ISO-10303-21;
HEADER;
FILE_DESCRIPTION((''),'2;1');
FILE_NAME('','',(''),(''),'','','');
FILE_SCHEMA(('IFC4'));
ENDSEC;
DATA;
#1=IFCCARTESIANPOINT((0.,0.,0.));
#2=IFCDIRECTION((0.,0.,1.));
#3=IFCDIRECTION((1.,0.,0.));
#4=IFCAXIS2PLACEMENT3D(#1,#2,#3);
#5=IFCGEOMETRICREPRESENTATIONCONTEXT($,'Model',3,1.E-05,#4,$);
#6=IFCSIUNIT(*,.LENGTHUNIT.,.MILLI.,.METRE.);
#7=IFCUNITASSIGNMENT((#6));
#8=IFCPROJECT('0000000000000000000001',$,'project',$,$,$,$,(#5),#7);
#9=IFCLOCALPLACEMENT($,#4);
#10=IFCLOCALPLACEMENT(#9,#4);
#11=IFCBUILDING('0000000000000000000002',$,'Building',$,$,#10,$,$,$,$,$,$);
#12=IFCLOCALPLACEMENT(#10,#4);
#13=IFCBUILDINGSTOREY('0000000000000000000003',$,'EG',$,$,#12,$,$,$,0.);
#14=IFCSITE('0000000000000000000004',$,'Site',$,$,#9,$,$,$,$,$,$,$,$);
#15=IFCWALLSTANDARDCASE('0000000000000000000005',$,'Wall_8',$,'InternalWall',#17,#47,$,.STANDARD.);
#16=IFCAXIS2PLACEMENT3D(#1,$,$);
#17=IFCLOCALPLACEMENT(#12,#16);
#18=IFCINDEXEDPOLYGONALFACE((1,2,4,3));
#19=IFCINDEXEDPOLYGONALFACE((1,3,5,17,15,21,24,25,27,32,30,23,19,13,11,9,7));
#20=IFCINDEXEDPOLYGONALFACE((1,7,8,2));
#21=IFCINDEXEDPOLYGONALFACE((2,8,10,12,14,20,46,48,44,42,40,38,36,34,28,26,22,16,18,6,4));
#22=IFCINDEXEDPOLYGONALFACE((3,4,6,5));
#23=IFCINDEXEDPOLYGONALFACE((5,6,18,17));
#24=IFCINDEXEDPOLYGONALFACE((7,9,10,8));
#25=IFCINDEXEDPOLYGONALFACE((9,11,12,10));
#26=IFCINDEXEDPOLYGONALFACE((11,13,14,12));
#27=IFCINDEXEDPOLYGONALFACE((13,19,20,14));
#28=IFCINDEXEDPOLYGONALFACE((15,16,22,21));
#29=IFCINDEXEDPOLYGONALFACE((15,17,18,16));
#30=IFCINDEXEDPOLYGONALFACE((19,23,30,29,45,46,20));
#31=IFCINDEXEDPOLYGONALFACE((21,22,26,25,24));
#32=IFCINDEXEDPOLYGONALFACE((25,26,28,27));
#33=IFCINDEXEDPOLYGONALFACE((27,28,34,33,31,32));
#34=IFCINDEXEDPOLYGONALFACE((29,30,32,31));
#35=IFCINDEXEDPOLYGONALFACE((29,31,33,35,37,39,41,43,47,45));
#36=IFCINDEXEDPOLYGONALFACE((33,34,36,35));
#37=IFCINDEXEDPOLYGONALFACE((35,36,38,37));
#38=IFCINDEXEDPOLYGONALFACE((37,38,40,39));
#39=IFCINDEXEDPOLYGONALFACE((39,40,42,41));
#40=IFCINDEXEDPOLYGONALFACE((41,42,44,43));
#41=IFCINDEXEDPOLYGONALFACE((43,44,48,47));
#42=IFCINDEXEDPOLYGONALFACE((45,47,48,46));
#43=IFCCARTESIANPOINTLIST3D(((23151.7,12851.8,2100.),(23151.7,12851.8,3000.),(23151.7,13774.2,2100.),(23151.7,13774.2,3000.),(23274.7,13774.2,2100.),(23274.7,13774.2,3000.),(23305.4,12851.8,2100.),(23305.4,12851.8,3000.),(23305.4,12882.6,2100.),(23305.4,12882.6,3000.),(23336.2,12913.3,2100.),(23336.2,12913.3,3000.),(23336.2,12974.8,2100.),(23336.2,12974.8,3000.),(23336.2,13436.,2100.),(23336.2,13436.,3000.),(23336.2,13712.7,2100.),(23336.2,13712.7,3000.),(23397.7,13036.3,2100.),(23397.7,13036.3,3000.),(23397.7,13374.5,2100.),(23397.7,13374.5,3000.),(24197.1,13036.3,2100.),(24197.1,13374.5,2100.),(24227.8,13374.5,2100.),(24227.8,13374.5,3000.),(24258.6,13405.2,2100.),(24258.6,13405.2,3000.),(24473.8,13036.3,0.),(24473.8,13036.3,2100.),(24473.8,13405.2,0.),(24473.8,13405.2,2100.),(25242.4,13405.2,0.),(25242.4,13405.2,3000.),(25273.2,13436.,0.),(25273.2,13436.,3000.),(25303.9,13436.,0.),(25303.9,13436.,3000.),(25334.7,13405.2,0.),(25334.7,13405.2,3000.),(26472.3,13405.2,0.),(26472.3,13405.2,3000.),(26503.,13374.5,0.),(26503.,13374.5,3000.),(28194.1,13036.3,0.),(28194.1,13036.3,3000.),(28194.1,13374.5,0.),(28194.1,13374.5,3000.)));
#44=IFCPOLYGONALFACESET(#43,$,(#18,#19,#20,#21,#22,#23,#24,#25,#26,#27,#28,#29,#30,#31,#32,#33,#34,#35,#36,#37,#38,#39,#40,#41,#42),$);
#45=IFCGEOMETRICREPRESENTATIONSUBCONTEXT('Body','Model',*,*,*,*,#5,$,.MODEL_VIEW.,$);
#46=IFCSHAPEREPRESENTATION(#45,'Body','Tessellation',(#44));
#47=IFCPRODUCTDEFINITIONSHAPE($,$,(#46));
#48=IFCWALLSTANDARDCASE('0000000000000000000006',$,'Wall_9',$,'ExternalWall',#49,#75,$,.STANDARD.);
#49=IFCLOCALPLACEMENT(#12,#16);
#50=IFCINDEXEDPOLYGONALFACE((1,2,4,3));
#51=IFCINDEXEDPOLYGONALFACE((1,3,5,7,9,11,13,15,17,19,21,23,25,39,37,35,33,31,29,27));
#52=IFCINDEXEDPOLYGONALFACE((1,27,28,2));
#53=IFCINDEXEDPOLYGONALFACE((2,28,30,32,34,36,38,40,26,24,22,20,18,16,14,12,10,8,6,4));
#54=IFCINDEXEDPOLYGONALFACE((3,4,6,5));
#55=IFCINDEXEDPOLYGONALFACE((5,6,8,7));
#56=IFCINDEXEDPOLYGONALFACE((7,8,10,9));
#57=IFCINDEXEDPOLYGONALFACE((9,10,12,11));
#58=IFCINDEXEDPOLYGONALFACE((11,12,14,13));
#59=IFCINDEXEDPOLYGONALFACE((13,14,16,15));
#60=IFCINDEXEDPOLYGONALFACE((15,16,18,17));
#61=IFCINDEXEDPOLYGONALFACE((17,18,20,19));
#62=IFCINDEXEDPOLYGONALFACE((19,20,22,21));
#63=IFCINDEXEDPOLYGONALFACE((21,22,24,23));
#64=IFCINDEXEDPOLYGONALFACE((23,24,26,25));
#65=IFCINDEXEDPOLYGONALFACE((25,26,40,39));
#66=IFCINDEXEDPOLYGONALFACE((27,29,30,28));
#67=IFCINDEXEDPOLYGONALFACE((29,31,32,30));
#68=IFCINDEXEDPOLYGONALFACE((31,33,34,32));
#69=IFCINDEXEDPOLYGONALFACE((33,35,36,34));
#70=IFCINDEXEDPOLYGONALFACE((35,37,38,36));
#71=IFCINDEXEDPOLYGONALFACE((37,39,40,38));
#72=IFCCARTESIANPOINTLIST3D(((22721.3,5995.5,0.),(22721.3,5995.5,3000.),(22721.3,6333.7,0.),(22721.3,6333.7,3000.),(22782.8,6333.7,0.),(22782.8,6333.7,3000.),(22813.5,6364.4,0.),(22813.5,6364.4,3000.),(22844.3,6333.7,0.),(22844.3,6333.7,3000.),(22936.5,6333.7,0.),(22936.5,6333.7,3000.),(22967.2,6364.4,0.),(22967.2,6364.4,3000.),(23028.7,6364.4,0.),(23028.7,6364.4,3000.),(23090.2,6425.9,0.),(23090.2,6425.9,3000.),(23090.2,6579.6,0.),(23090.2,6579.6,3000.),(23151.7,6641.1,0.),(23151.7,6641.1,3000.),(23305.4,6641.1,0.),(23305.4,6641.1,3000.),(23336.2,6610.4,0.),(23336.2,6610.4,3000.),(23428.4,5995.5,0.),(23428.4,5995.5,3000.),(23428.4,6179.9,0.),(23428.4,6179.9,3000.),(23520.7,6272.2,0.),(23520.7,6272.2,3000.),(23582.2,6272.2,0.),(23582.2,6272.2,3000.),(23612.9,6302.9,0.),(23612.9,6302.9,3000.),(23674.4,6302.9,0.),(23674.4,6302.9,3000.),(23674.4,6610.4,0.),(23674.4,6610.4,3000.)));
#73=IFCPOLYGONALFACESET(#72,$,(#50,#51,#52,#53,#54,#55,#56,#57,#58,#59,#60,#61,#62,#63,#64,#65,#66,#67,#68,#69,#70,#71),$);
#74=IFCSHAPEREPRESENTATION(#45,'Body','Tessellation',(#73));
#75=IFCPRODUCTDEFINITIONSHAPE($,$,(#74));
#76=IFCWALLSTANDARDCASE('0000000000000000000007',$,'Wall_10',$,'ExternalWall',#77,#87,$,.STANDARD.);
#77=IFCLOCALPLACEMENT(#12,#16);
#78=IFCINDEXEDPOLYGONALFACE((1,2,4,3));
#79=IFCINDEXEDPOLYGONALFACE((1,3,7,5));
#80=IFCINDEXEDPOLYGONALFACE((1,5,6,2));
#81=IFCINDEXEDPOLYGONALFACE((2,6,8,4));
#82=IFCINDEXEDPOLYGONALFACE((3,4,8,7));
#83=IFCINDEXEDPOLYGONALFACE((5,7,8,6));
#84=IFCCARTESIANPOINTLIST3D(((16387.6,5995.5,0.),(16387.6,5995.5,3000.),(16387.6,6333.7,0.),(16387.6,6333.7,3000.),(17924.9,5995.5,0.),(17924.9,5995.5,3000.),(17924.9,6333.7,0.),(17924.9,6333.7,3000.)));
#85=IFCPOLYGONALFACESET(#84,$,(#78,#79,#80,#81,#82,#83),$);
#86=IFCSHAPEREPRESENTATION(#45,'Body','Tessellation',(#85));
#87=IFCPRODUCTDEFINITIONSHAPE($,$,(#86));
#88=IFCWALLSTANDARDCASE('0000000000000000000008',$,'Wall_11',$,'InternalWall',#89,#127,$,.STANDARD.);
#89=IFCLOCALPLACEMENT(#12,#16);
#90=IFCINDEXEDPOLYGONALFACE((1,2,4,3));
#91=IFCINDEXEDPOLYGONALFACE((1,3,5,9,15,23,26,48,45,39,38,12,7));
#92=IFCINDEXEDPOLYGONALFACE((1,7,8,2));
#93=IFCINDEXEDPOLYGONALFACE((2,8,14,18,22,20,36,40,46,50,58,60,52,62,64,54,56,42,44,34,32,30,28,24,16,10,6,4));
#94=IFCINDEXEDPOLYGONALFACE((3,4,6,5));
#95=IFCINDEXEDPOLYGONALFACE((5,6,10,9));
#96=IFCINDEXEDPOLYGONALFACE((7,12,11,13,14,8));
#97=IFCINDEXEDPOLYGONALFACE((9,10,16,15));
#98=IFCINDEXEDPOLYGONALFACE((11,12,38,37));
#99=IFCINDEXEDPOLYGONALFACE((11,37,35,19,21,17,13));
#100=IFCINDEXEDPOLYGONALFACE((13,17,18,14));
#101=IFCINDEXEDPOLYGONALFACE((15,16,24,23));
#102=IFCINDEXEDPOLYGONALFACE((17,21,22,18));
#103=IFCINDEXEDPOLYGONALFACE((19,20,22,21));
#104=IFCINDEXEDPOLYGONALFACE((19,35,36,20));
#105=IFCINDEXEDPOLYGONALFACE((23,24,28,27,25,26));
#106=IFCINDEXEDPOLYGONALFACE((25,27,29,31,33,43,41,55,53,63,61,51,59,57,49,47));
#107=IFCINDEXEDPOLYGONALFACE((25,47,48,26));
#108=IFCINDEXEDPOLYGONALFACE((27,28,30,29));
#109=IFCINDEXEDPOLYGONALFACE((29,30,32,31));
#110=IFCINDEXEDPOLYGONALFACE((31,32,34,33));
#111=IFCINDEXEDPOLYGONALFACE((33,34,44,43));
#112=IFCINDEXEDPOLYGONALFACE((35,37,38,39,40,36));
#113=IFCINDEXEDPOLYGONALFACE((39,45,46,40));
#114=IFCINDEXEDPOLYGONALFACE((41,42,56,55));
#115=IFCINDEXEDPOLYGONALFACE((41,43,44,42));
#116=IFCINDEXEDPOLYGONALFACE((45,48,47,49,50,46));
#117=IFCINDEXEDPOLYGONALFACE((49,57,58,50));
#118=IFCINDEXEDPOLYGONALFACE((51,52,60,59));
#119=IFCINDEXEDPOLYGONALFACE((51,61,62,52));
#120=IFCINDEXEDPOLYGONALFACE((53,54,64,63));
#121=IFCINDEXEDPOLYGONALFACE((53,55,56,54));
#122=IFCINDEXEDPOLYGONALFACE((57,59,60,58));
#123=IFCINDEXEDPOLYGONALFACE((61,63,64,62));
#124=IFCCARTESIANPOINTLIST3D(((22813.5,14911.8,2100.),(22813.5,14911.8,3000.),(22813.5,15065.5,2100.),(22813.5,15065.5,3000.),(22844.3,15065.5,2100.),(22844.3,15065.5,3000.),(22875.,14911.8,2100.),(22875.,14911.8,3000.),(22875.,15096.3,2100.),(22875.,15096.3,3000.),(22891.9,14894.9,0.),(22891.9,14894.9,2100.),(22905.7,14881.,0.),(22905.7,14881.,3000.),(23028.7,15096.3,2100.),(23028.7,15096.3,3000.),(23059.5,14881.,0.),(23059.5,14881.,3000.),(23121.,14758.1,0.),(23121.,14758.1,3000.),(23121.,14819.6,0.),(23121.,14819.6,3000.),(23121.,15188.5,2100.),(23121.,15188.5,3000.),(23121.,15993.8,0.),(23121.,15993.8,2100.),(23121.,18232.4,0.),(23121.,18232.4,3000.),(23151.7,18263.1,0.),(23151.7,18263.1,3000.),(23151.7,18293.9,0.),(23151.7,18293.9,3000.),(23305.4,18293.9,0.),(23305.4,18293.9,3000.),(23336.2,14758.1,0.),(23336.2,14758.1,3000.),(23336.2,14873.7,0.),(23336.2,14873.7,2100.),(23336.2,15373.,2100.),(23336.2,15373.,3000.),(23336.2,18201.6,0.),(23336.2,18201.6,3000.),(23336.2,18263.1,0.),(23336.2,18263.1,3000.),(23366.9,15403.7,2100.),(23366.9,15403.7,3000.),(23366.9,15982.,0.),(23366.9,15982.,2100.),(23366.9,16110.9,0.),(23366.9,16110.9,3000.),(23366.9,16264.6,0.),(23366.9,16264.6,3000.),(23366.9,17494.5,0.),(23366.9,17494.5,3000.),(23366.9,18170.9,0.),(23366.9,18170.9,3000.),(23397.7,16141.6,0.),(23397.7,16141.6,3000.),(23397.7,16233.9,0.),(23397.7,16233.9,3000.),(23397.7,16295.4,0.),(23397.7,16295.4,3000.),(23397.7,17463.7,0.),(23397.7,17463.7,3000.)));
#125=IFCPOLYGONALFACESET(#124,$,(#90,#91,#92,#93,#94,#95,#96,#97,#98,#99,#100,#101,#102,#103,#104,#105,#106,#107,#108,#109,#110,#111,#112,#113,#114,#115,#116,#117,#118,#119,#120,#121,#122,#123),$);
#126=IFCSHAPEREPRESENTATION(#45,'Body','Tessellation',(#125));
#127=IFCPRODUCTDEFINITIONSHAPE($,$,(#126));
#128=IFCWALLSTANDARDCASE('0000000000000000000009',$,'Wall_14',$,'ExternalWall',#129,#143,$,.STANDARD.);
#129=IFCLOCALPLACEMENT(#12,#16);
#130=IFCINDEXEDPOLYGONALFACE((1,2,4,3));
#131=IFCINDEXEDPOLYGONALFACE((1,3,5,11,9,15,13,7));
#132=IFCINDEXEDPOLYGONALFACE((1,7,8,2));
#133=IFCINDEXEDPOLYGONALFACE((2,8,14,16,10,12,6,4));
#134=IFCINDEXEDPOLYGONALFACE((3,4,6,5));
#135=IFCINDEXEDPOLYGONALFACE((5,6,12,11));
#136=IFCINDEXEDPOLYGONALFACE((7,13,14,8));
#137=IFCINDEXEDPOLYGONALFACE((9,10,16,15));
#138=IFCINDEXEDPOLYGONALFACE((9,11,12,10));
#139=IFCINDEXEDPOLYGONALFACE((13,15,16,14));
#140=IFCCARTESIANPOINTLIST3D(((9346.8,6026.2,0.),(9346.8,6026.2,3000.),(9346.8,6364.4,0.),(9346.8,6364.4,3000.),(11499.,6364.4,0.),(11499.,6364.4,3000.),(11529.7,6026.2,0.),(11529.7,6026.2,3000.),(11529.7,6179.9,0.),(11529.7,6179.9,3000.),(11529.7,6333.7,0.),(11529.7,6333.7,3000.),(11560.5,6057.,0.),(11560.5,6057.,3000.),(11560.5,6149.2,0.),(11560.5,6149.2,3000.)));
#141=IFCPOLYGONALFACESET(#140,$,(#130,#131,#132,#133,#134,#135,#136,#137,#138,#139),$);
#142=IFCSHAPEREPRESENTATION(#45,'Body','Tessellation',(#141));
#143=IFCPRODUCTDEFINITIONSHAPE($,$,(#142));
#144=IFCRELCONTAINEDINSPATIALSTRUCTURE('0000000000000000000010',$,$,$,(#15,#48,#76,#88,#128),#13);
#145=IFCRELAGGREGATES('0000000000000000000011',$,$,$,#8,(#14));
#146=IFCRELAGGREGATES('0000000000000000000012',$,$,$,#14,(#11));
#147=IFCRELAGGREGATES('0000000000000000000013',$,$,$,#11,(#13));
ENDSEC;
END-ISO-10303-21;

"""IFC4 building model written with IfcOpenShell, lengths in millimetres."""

from ifc_helpers import new_model, si_unit, frame, origin_with_axes, place, context, subcontext, project, spatial, polyline, rectangle, outline, extrude, element, save


model = new_model("IFC4")

# Units and contexts
model_context = context("Model", 3, precision=1e-05, world=origin_with_axes())
body_context = subcontext(model_context, "Body", "Model", "MODEL_VIEW")
ifc_project = project(units=[si_unit("LENGTHUNIT", "METRE", prefix="MILLI")], contexts=[model_context])

# Site, building, storey
site_placement = place(None, origin_with_axes())
site = spatial("IfcSite", under=ifc_project, at=site_placement, Name="Site")
building_placement = place(site_placement, origin_with_axes())
building = spatial("IfcBuilding", under=site, at=building_placement, Name="Building")
storey_placement = place(building_placement, origin_with_axes())
storey = spatial("IfcBuildingStorey", under=building, at=storey_placement, Name="EG", Elevation=0.0)

# Walls, openings
wall_1_placement = place(storey_placement, origin_with_axes())
wall_1 = element("IfcWallStandardCase", 1, at=wall_1_placement, inside=storey, Name="Wall_8", ObjectType="InternalWall", PredefinedType="STANDARD", context=body_context, shape_type="SweptSolid", body=[
    extrude(outline(polyline([(23151.7, 12851.8, 0.0), (23151.7, 13774.2, 0.0), (23274.7, 13774.2, 0.0), (23336.2, 13712.7, 0.0), (23336.2, 13436.0, 0.0), (23397.7, 13374.5, 0.0), (24227.8, 13374.5, 0.0), (24258.6, 13405.2, 0.0), (25242.4, 13405.2, 0.0), (25273.2, 13436.0, 0.0), (25303.9, 13436.0, 0.0), (25334.7, 13405.2, 0.0), (26472.3, 13405.2, 0.0), (26503.0, 13374.5, 0.0), (28194.1, 13374.5, 0.0), (28194.1, 13036.3, 0.0), (23397.7, 13036.3, 0.0), (23336.2, 12974.8, 0.0), (23336.2, 12913.3, 0.0), (23305.4, 12882.6, 0.0), (23305.4, 12851.8, 0.0), (23151.7, 12851.8, 0.0)])), origin_with_axes(), (0.0, 0.0, 1.0), 3000.0),
])
opening_1_placement = place(wall_1_placement, origin_with_axes())
element("IfcOpeningElement", 2, at=opening_1_placement, inside=storey, cuts=wall_1, context=body_context, shape_type="SweptSolid", body=[
    extrude(rectangle(XDim=1322.1, YDim=922.4), frame((23812.8, 13313.0, 0.0), z_axis=(0.0, 0.0, 1.0), x_axis=(1.0, 0.0, 0.0)), (0.0, 0.0, 1.0), 2100.0),
])
opening_2_placement = place(wall_1_placement, origin_with_axes())
element("IfcOpeningElement", 3, at=opening_2_placement, inside=storey, cuts=wall_1, context=body_context, shape_type="SweptSolid", body=[
    extrude(rectangle(XDim=1045.4, YDim=922.4), frame((23674.4, 13313.0, 0.0), z_axis=(0.0, 0.0, 1.0), x_axis=(1.0, 0.0, 0.0)), (0.0, 0.0, 1.0), 2100.0),
])
wall_2_placement = place(storey_placement, origin_with_axes())
wall_2 = element("IfcWallStandardCase", 4, at=wall_2_placement, inside=storey, Name="Wall_9", ObjectType="ExternalWall", PredefinedType="STANDARD", context=body_context, shape_type="SweptSolid", body=[
    extrude(outline(polyline([(22721.3, 5995.5, 0.0), (22721.3, 6333.7, 0.0), (22782.8, 6333.7, 0.0), (22813.5, 6364.4, 0.0), (22844.3, 6333.7, 0.0), (22936.5, 6333.7, 0.0), (22967.2, 6364.4, 0.0), (23028.7, 6364.4, 0.0), (23090.2, 6425.9, 0.0), (23090.2, 6579.6, 0.0), (23151.7, 6641.1, 0.0), (23305.4, 6641.1, 0.0), (23336.2, 6610.4, 0.0), (23674.4, 6610.4, 0.0), (23674.4, 6302.9, 0.0), (23612.9, 6302.9, 0.0), (23582.2, 6272.2, 0.0), (23520.7, 6272.2, 0.0), (23428.4, 6179.9, 0.0), (23428.4, 5995.5, 0.0), (22721.3, 5995.5, 0.0)])), origin_with_axes(), (0.0, 0.0, 1.0), 3000.0),
])
opening_3_placement = place(wall_2_placement, origin_with_axes())
element("IfcOpeningElement", 5, at=opening_3_placement, inside=storey, cuts=wall_2, context=body_context, shape_type="SweptSolid", body=[
    extrude(rectangle(XDim=1200.0, YDim=645.7), frame((21937.3, 6148.9, 1000.0), z_axis=(0.0, 0.0, 1.0), x_axis=(1.0, 0.0, 0.0)), (0.0, 0.0, 1.0), 1000.0),
])
opening_4_placement = place(wall_2_placement, origin_with_axes())
element("IfcOpeningElement", 6, at=opening_4_placement, inside=storey, cuts=wall_2, context=body_context, shape_type="SweptSolid", body=[
    extrude(rectangle(XDim=1200.0, YDim=645.7), frame((25765.1, 6502.8, 1000.0), z_axis=(0.0, 0.0, 1.0), x_axis=(1.0, 0.0, 0.0)), (0.0, 0.0, 1.0), 1000.0),
])

# Wall
wall_3_placement = place(storey_placement, origin_with_axes())
element("IfcWallStandardCase", 7, at=wall_3_placement, inside=storey, Name="Wall_10", ObjectType="ExternalWall", PredefinedType="STANDARD", context=body_context, shape_type="SweptSolid", body=[
    extrude(outline(polyline([(16387.6, 5995.5, 0.0), (16387.6, 6333.7, 0.0), (17924.9, 6333.7, 0.0), (17924.9, 5995.5, 0.0), (16387.6, 5995.5, 0.0)])), origin_with_axes(), (0.0, 0.0, 1.0), 3000.0),
])

# Walls, openings
wall_4_placement = place(storey_placement, origin_with_axes())
wall_4 = element("IfcWallStandardCase", 8, at=wall_4_placement, inside=storey, Name="Wall_11", ObjectType="InternalWall", PredefinedType="STANDARD", context=body_context, shape_type="SweptSolid", body=[
    extrude(outline(polyline([(23121.0, 14758.1, 0.0), (23121.0, 14819.6, 0.0), (23059.5, 14881.0, 0.0), (22905.7, 14881.0, 0.0), (22875.0, 14911.8, 0.0), (22813.5, 14911.8, 0.0), (22813.5, 15065.5, 0.0), (22844.3, 15065.5, 0.0), (22875.0, 15096.3, 0.0), (23028.7, 15096.3, 0.0), (23121.0, 15188.5, 0.0), (23121.0, 18232.4, 0.0), (23151.7, 18263.1, 0.0), (23151.7, 18293.9, 0.0), (23305.4, 18293.9, 0.0), (23336.2, 18263.1, 0.0), (23336.2, 18201.6, 0.0), (23366.9, 18170.9, 0.0), (23366.9, 17494.5, 0.0), (23397.7, 17463.7, 0.0), (23397.7, 16295.4, 0.0), (23366.9, 16264.6, 0.0), (23397.7, 16233.9, 0.0), (23397.7, 16141.6, 0.0), (23366.9, 16110.9, 0.0), (23366.9, 15403.7, 0.0), (23336.2, 15373.0, 0.0), (23336.2, 14758.1, 0.0), (23121.0, 14758.1, 0.0)])), origin_with_axes(), (0.0, 0.0, 1.0), 3000.0),
])
opening_5_placement = place(wall_4_placement, origin_with_axes())
element("IfcOpeningElement", 9, at=opening_5_placement, inside=storey, cuts=wall_4, context=body_context, shape_type="SweptSolid", body=[
    extrude(rectangle(XDim=1108.5, YDim=536.7), frame((23100.0, 15439.9, 0.0), z_axis=(0.0, 0.0, 1.0), x_axis=(-0.047565, -0.998868, 0.0)), (0.0, 0.0, 1.0), 2100.0),
])
wall_5_placement = place(storey_placement, origin_with_axes())
wall_5 = element("IfcWallStandardCase", 10, at=wall_5_placement, inside=storey, Name="Wall_14", ObjectType="ExternalWall", PredefinedType="STANDARD", context=body_context, shape_type="SweptSolid", body=[
    extrude(outline(polyline([(9346.8, 6026.2, 0.0), (9346.8, 6364.4, 0.0), (11499.0, 6364.4, 0.0), (11529.7, 6333.7, 0.0), (11529.7, 6179.9, 0.0), (11560.5, 6149.2, 0.0), (11560.5, 6057.0, 0.0), (11529.7, 6026.2, 0.0), (9346.8, 6026.2, 0.0)])), origin_with_axes(), (0.0, 0.0, 1.0), 3000.0),
])
opening_6_placement = place(wall_5_placement, origin_with_axes())
element("IfcOpeningElement", 11, at=opening_6_placement, inside=storey, cuts=wall_5, context=body_context, shape_type="SweptSolid", body=[
    extrude(rectangle(XDim=1200.0, YDim=338.2), frame((12359.2, 6195.2, 1000.0), z_axis=(0.0, 0.0, 1.0), x_axis=(1.0, 0.0, 0.0)), (0.0, 0.0, 1.0), 1000.0),
])

save(model, "model.ifc")
